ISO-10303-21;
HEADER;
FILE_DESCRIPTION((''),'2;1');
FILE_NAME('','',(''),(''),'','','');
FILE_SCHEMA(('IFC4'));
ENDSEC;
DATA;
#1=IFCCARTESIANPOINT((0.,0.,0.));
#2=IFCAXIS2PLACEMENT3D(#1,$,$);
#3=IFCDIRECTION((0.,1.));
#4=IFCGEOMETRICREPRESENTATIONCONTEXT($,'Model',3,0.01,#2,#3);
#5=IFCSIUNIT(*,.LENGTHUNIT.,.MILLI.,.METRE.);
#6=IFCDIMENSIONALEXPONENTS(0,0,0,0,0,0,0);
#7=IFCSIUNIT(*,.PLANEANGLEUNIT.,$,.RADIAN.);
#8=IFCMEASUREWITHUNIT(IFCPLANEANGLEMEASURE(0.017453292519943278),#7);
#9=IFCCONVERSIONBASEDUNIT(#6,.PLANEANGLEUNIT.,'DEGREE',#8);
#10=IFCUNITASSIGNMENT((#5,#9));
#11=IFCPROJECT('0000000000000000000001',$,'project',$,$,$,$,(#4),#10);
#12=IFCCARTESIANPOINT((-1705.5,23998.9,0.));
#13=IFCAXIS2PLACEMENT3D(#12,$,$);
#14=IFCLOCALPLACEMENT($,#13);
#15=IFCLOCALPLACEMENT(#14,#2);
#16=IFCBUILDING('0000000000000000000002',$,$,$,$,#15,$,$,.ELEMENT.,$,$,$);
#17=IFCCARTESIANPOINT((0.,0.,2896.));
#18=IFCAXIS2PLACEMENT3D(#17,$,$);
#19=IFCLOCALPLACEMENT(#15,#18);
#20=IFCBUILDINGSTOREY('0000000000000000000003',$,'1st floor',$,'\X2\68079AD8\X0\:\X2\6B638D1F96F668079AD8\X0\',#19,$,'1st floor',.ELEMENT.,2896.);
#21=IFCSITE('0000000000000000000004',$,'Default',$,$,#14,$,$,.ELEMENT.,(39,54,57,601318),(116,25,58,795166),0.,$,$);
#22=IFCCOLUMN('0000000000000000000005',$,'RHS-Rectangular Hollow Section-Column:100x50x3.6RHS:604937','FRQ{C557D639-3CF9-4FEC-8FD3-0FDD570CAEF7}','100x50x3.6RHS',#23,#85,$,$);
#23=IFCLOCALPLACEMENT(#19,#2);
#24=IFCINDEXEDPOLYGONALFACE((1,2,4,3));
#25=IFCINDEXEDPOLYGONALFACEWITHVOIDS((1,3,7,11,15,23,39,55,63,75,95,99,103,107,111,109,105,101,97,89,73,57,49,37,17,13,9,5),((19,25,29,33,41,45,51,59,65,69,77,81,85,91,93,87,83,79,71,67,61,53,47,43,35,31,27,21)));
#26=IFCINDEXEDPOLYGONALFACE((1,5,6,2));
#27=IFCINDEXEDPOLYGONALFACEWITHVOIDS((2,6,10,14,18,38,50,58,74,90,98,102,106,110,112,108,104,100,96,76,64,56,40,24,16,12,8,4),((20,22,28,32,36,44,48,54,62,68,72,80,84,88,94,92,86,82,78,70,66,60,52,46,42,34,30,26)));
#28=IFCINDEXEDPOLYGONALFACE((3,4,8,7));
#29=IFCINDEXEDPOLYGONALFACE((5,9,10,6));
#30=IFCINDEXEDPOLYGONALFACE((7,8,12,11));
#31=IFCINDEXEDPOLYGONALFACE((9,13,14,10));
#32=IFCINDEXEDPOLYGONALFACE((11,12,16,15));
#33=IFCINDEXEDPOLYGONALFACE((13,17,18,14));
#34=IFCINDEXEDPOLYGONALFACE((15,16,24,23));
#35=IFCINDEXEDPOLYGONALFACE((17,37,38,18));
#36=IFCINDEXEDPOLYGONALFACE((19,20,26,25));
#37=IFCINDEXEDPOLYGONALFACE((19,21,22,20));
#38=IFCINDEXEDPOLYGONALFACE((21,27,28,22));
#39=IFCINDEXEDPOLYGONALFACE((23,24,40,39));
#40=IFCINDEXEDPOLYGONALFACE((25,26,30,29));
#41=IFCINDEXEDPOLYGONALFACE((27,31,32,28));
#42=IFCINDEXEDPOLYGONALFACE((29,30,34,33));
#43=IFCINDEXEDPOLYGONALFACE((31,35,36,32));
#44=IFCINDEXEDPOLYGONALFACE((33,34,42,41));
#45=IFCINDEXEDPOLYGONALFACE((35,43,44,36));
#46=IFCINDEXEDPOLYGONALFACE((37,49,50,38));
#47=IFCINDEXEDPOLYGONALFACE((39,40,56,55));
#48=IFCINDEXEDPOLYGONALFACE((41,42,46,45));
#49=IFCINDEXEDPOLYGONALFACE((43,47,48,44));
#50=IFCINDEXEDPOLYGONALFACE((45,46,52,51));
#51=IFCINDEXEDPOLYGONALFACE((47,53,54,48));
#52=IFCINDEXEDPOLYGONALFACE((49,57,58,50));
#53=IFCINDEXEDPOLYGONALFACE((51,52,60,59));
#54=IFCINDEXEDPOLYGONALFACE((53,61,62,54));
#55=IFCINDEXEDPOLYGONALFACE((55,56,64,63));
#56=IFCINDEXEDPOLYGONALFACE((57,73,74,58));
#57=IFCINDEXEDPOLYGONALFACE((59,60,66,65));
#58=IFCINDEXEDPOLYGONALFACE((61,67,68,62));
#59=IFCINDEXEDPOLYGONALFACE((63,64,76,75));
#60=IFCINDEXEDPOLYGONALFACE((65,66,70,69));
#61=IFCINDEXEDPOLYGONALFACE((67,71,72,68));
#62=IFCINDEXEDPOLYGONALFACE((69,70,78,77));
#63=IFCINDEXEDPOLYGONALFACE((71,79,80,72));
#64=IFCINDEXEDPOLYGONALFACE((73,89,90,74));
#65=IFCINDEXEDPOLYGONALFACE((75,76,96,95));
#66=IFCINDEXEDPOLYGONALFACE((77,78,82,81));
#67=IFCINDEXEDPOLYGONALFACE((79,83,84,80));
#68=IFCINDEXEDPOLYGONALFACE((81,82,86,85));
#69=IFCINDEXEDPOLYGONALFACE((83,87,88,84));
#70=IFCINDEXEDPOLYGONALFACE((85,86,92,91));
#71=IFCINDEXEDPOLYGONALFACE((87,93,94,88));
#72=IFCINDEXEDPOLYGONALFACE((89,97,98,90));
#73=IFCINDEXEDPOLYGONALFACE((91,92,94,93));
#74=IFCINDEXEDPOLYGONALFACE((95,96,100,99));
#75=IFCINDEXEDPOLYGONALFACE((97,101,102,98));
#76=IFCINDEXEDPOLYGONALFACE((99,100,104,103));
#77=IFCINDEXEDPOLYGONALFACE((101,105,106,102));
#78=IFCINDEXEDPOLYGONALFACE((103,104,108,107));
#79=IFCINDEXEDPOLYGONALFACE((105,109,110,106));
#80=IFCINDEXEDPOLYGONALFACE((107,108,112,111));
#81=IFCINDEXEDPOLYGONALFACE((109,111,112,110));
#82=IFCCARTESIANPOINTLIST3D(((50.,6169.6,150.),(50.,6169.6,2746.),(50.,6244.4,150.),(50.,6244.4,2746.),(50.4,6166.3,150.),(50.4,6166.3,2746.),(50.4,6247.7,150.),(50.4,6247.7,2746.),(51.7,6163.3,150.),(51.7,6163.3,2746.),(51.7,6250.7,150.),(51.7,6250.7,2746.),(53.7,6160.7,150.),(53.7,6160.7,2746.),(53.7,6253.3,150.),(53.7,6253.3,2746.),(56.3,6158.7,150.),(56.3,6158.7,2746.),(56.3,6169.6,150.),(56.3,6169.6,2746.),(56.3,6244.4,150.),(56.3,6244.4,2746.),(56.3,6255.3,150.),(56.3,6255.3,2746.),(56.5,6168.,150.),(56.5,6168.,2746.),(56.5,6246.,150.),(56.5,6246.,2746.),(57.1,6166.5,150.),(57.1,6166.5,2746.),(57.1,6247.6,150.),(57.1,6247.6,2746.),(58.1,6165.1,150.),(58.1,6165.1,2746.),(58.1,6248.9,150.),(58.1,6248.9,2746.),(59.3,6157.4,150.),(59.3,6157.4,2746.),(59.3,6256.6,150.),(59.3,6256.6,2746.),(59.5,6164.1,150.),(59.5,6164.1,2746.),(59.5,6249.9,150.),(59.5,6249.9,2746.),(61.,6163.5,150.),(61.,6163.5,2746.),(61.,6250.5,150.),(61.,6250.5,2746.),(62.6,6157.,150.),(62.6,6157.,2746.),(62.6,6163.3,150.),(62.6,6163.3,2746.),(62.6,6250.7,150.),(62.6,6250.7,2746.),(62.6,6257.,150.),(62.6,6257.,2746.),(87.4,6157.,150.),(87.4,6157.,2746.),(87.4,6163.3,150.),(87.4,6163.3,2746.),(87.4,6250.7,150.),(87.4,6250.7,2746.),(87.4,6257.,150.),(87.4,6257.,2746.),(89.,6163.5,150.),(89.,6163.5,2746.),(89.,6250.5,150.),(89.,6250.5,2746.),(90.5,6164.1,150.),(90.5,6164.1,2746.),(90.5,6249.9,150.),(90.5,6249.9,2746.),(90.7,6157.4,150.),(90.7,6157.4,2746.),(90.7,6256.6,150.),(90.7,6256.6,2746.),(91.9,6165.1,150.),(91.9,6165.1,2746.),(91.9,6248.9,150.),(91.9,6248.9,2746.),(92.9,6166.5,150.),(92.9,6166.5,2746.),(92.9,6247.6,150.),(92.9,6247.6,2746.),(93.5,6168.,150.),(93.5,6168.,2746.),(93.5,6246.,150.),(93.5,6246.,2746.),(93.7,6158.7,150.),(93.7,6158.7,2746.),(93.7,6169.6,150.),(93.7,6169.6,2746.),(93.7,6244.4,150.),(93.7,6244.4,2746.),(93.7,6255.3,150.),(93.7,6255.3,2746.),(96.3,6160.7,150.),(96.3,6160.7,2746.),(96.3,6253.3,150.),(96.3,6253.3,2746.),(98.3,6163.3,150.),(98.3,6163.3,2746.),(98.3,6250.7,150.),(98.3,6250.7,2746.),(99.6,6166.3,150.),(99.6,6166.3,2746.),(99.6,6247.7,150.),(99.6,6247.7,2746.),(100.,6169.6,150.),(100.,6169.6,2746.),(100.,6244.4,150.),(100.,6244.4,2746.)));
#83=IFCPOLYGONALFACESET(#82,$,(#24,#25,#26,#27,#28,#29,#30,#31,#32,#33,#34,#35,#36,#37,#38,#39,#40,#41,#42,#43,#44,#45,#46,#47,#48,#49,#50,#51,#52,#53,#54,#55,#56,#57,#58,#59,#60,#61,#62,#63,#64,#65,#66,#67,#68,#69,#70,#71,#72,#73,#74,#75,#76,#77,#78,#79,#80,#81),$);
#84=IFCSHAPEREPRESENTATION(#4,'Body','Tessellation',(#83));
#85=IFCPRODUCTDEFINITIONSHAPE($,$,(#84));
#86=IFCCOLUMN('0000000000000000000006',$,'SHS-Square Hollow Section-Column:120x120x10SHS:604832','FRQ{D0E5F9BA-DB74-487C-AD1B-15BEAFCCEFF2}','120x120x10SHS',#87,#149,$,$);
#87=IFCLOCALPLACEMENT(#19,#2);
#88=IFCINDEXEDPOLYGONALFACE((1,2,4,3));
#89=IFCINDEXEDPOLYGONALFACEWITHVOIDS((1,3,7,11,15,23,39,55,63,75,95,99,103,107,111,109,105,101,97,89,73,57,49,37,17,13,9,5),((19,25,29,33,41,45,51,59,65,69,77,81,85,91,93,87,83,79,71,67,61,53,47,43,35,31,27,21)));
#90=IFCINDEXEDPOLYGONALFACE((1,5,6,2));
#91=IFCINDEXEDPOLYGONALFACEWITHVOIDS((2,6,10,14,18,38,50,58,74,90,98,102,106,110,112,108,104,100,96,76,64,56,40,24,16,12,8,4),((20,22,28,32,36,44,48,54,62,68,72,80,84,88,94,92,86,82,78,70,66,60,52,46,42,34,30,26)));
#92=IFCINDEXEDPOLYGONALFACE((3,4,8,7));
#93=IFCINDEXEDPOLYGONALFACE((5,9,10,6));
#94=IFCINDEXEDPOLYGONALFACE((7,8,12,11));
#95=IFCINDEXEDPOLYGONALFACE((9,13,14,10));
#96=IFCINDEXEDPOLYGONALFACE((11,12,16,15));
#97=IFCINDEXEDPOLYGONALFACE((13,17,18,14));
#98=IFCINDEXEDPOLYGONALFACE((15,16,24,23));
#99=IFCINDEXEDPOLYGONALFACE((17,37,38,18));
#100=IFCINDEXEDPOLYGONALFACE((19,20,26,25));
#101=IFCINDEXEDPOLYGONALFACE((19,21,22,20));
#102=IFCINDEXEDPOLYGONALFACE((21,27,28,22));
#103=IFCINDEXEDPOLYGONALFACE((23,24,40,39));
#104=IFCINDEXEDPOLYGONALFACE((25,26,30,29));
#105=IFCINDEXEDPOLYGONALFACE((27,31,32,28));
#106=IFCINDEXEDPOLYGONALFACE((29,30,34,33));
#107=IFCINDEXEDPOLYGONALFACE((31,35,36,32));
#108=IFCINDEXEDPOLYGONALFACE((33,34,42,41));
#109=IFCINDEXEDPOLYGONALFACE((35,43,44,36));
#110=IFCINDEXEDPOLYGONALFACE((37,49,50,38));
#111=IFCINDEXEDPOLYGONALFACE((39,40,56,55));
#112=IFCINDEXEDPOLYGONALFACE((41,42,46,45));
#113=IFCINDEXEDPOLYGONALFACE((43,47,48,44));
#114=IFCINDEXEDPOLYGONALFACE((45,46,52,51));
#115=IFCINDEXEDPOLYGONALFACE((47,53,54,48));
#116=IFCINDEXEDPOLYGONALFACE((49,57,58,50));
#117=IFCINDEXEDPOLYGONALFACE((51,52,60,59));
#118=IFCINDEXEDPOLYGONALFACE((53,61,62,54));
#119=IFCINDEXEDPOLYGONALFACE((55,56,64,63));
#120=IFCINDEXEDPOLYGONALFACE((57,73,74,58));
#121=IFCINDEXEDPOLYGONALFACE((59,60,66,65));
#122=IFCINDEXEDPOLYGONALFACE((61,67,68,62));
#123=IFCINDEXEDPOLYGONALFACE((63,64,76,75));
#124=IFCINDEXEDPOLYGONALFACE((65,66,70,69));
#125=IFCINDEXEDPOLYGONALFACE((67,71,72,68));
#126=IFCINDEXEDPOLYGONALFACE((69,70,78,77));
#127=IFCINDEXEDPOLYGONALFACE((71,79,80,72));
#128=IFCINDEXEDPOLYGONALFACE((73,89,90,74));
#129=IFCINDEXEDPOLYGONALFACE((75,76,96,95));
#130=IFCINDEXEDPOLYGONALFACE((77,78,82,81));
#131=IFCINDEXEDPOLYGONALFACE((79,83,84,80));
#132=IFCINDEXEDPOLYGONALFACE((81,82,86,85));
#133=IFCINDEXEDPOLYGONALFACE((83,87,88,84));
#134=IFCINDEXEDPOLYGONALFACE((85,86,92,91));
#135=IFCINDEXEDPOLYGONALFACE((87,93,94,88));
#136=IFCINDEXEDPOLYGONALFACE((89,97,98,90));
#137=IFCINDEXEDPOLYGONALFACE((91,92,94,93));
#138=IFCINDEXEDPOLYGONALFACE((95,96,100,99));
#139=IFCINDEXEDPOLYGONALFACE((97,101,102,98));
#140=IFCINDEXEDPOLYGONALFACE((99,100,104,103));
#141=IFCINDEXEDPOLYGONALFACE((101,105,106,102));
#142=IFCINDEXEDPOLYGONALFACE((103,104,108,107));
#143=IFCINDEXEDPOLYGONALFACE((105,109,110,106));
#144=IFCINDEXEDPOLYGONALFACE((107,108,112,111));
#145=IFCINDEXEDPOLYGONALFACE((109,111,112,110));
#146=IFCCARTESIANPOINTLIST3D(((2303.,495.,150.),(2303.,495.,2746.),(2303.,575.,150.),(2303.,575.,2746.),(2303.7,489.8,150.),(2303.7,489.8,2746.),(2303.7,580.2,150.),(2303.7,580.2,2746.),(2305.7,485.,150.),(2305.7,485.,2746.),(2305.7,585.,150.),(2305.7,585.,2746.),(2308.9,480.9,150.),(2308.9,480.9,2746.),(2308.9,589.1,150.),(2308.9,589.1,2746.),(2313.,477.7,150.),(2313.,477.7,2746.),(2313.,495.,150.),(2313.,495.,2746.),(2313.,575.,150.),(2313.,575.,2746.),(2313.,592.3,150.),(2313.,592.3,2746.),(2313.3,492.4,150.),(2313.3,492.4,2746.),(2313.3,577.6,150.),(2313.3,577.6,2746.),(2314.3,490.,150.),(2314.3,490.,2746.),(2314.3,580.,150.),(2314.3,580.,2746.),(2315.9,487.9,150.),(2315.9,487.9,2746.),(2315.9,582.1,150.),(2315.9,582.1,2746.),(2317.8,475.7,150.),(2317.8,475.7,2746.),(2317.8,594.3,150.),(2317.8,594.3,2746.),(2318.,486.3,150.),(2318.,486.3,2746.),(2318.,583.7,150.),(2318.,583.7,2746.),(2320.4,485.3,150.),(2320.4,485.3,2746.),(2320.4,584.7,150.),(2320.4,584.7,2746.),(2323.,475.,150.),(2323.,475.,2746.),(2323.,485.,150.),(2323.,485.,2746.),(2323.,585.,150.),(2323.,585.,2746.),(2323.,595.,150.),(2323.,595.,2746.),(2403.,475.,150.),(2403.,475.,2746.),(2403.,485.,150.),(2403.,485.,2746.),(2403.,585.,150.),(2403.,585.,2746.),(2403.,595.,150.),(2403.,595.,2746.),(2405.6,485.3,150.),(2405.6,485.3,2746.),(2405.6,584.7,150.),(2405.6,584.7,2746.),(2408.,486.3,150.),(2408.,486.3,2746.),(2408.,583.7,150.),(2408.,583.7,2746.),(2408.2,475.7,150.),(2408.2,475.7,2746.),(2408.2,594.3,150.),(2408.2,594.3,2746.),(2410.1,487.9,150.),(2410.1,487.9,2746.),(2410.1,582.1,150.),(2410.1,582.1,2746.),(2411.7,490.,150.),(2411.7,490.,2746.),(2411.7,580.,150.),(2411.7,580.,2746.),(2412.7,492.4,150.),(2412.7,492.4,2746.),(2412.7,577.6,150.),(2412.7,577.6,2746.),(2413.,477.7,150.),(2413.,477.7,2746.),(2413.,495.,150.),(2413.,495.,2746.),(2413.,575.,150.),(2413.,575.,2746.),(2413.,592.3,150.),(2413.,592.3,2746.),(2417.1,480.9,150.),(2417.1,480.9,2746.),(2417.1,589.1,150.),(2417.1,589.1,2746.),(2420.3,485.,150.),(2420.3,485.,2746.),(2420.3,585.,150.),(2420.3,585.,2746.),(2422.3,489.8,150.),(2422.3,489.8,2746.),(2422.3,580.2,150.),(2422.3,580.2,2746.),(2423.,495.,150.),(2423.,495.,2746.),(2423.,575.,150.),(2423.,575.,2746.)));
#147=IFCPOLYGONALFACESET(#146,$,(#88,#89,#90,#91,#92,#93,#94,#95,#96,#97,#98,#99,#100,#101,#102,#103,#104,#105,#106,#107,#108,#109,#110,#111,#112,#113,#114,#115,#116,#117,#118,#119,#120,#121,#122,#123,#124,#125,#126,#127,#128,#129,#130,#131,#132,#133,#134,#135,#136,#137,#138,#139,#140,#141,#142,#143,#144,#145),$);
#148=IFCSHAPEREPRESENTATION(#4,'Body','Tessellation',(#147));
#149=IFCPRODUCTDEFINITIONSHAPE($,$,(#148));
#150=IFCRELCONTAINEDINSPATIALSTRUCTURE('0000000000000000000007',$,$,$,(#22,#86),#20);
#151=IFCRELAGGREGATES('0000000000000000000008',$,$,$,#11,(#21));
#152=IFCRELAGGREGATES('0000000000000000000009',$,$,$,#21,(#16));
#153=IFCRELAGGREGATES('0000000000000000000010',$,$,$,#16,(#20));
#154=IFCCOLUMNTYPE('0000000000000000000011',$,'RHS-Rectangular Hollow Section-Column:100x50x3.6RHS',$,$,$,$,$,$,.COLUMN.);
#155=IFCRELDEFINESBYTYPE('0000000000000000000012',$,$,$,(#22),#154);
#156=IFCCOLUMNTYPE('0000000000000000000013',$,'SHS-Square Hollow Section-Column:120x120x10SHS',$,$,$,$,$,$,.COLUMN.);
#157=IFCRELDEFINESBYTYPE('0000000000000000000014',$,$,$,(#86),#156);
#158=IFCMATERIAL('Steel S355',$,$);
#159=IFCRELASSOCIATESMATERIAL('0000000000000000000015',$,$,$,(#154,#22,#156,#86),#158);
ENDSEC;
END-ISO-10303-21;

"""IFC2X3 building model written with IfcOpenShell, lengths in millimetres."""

from ifc_helpers import new_model, entity, si_unit, converted_unit, direction, frame, origin, origin_2d, place, context, project, spatial, hollow_rectangle, extrude, clip, halfspace, material, type_object, element, save


model = new_model("IFC2X3")

# Units and contexts
model_context = context("Model", 3, precision=0.01, world=origin(), true_north=direction((0.0, 1.0)))
ifc_project = project(units=[si_unit("LENGTHUNIT", "METRE", prefix="MILLI"), converted_unit("PLANEANGLEUNIT", "DEGREE", entity("IfcPlaneAngleMeasure", 0.017453292519943278), si_unit("PLANEANGLEUNIT", "RADIAN"), dimensions=[0, 0, 0, 0, 0, 0, 0])], contexts=[model_context])

# Site, building, storey
site_placement = place(None, frame((-1705.5, 23998.9, 0.0)))
site = spatial("IfcSite", under=ifc_project, at=site_placement, Name="Default", CompositionType="ELEMENT", RefLatitude=(39, 54, 57, 601318), RefLongitude=(116, 25, 58, 795166), RefElevation=0.0)
building_placement = place(site_placement, origin())
building = spatial("IfcBuilding", under=site, at=building_placement, CompositionType="ELEMENT")
storey_placement = place(building_placement, frame((0.0, 0.0, 2896.0)))
storey = spatial("IfcBuildingStorey", under=building, at=storey_placement, Name="1st floor", ObjectType="标高:正负零标高", LongName="1st floor", CompositionType="ELEMENT", Elevation=2896.0)

# Shared definitions
ifc_material_1 = material(Name="Steel S355")

# Columns
column_type_1 = type_object("IfcColumnType", Name="RHS-Rectangular Hollow Section-Column:100x50x3.6RHS", PredefinedType="COLUMN", material=ifc_material_1)
column_1_placement = place(storey_placement, frame((75.0, 6207.0, 2746.0), z_axis=(0.0, 0.0, 1.0), x_axis=(-1.0, 0.0, 0.0)))
element("IfcColumn", 1, at=column_1_placement, inside=storey, type_object=column_type_1, material=ifc_material_1, Name="RHS-Rectangular Hollow Section-Column:100x50x3.6RHS:604937", Description="FRQ{C557D639-3CF9-4FEC-8FD3-0FDD570CAEF7}", ObjectType="100x50x3.6RHS", context=model_context, shape_type="Clipping", body=[
    clip(extrude(hollow_rectangle(XDim=50.0, YDim=100.0, WallThickness=6.3, InnerFilletRadius=6.3, OuterFilletRadius=12.6, at=origin_2d()), origin(), (0.0, 0.0, -1.0), 2651.9), halfspace(frame((75.0, 6207.0, -2596.0), z_axis=(0.0, 0.0, 1.0), x_axis=(-1.0, 0.0, 0.0)), True)),
])
column_type_2 = type_object("IfcColumnType", Name="SHS-Square Hollow Section-Column:120x120x10SHS", PredefinedType="COLUMN", material=ifc_material_1)
column_2_placement = place(storey_placement, frame((2363.0, 535.0, 2746.0), z_axis=(0.0, 0.0, 1.0), x_axis=(0.0, -1.0, 0.0)))
element("IfcColumn", 2, at=column_2_placement, inside=storey, type_object=column_type_2, material=ifc_material_1, Name="SHS-Square Hollow Section-Column:120x120x10SHS:604832", Description="FRQ{D0E5F9BA-DB74-487C-AD1B-15BEAFCCEFF2}", ObjectType="120x120x10SHS", context=model_context, shape_type="Clipping", body=[
    clip(extrude(hollow_rectangle(XDim=120.0, YDim=120.0, WallThickness=10.0, InnerFilletRadius=10.0, OuterFilletRadius=20.0, at=origin_2d()), origin(), (0.0, 0.0, -1.0), 2680.9), halfspace(frame((535.0, -2363.0, -2596.0), z_axis=(0.0, 0.0, 1.0), x_axis=(0.0, 1.0, 0.0)), True)),
])

save(model, "model.ifc")
